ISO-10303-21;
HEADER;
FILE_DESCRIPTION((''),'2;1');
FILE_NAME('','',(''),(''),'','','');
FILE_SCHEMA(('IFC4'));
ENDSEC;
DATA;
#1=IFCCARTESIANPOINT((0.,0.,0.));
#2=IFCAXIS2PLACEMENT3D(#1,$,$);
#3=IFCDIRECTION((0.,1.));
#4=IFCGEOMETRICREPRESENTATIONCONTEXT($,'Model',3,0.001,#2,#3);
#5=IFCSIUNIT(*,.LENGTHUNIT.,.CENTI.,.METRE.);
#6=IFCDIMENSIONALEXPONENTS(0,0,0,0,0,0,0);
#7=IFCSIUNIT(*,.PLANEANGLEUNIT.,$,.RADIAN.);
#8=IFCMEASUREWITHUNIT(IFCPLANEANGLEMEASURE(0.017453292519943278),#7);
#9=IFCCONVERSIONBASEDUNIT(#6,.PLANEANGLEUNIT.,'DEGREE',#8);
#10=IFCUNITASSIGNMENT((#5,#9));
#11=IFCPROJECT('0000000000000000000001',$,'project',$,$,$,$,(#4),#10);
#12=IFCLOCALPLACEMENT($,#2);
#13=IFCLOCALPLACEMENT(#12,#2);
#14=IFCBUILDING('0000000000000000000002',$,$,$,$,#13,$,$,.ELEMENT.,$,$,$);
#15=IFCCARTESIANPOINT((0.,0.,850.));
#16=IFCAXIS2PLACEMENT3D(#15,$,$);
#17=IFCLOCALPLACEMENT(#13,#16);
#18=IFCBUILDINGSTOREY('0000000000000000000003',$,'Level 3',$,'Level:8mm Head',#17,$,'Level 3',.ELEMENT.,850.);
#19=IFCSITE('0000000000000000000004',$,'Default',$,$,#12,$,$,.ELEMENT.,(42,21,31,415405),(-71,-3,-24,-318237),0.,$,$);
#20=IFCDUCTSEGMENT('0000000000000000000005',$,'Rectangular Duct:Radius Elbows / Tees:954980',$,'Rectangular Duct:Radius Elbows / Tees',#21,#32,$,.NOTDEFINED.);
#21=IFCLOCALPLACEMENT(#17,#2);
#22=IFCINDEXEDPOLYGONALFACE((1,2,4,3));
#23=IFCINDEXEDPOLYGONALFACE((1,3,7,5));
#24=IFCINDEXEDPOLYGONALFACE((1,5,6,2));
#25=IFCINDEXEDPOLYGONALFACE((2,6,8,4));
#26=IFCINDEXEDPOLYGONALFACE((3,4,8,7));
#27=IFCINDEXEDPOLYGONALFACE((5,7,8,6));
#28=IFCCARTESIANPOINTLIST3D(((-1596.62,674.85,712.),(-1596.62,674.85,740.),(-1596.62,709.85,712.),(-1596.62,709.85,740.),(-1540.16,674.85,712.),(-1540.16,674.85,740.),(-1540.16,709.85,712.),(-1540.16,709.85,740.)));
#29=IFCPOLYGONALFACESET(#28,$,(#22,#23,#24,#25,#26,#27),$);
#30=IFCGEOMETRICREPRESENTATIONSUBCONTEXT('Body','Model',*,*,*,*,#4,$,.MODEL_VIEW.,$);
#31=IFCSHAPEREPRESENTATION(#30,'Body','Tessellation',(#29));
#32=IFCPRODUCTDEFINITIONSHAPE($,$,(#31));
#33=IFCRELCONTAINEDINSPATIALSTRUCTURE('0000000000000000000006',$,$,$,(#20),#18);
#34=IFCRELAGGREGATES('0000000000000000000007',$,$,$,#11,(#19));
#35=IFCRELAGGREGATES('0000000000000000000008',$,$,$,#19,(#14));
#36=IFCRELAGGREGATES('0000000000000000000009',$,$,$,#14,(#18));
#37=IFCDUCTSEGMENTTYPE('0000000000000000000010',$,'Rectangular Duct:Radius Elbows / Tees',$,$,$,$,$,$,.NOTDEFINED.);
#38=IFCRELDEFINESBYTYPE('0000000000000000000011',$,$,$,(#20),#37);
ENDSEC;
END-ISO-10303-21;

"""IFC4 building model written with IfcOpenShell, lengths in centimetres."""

from ifc_helpers import new_model, entity, si_unit, converted_unit, direction, frame, origin, place, context, subcontext, project, spatial, indexed_curve, outline, extrude, type_object, element, save


model = new_model("IFC4")

# Units and contexts
model_context = context("Model", 3, precision=0.001, world=origin(), true_north=direction((0.0, 1.0)))
body_context = subcontext(model_context, "Body", "Model", "MODEL_VIEW")
ifc_project = project(units=[si_unit("LENGTHUNIT", "METRE", prefix="CENTI"), converted_unit("PLANEANGLEUNIT", "DEGREE", entity("IfcPlaneAngleMeasure", 0.017453292519943278), si_unit("PLANEANGLEUNIT", "RADIAN"), dimensions=[0, 0, 0, 0, 0, 0, 0])], contexts=[model_context])

# Site, building, storey
site_placement = place(None, origin())
site = spatial("IfcSite", under=ifc_project, at=site_placement, Name="Default", CompositionType="ELEMENT", RefLatitude=(42, 21, 31, 415405), RefLongitude=(-71, -3, -24, -318237), RefElevation=0.0)
building_placement = place(site_placement, origin())
building = spatial("IfcBuilding", under=site, at=building_placement, CompositionType="ELEMENT")
storey_placement = place(building_placement, frame((0.0, 0.0, 850.0)))
storey = spatial("IfcBuildingStorey", under=building, at=storey_placement, Name="Level 3", ObjectType="Level:8mm Head", LongName="Level 3", CompositionType="ELEMENT", Elevation=850.0)

# Duct segment
duct_segment_type = type_object("IfcDuctSegmentType", Name="Rectangular Duct:Radius Elbows / Tees", PredefinedType="NOTDEFINED")
duct_segment_1_placement = place(storey_placement, origin())
element("IfcDuctSegment", 1, at=duct_segment_1_placement, inside=storey, type_object=duct_segment_type, Name="Rectangular Duct:Radius Elbows / Tees:954980", ObjectType="Rectangular Duct:Radius Elbows / Tees", PredefinedType="NOTDEFINED", context=body_context, shape_type="SweptSolid", body=[
    extrude(outline(indexed_curve([(-28.23, -17.5), (28.23, -17.5), (28.23, 17.5), (-28.23, 17.5), (-28.23, -17.5)], self_intersect=False)), frame((-1568.39, 692.35, 712.0), z_axis=(0.0, 0.0, 1.0), x_axis=(-1.0, 0.0, 0.0)), (0.0, 0.0, 1.0), 28.0),
])

save(model, "model.ifc")
